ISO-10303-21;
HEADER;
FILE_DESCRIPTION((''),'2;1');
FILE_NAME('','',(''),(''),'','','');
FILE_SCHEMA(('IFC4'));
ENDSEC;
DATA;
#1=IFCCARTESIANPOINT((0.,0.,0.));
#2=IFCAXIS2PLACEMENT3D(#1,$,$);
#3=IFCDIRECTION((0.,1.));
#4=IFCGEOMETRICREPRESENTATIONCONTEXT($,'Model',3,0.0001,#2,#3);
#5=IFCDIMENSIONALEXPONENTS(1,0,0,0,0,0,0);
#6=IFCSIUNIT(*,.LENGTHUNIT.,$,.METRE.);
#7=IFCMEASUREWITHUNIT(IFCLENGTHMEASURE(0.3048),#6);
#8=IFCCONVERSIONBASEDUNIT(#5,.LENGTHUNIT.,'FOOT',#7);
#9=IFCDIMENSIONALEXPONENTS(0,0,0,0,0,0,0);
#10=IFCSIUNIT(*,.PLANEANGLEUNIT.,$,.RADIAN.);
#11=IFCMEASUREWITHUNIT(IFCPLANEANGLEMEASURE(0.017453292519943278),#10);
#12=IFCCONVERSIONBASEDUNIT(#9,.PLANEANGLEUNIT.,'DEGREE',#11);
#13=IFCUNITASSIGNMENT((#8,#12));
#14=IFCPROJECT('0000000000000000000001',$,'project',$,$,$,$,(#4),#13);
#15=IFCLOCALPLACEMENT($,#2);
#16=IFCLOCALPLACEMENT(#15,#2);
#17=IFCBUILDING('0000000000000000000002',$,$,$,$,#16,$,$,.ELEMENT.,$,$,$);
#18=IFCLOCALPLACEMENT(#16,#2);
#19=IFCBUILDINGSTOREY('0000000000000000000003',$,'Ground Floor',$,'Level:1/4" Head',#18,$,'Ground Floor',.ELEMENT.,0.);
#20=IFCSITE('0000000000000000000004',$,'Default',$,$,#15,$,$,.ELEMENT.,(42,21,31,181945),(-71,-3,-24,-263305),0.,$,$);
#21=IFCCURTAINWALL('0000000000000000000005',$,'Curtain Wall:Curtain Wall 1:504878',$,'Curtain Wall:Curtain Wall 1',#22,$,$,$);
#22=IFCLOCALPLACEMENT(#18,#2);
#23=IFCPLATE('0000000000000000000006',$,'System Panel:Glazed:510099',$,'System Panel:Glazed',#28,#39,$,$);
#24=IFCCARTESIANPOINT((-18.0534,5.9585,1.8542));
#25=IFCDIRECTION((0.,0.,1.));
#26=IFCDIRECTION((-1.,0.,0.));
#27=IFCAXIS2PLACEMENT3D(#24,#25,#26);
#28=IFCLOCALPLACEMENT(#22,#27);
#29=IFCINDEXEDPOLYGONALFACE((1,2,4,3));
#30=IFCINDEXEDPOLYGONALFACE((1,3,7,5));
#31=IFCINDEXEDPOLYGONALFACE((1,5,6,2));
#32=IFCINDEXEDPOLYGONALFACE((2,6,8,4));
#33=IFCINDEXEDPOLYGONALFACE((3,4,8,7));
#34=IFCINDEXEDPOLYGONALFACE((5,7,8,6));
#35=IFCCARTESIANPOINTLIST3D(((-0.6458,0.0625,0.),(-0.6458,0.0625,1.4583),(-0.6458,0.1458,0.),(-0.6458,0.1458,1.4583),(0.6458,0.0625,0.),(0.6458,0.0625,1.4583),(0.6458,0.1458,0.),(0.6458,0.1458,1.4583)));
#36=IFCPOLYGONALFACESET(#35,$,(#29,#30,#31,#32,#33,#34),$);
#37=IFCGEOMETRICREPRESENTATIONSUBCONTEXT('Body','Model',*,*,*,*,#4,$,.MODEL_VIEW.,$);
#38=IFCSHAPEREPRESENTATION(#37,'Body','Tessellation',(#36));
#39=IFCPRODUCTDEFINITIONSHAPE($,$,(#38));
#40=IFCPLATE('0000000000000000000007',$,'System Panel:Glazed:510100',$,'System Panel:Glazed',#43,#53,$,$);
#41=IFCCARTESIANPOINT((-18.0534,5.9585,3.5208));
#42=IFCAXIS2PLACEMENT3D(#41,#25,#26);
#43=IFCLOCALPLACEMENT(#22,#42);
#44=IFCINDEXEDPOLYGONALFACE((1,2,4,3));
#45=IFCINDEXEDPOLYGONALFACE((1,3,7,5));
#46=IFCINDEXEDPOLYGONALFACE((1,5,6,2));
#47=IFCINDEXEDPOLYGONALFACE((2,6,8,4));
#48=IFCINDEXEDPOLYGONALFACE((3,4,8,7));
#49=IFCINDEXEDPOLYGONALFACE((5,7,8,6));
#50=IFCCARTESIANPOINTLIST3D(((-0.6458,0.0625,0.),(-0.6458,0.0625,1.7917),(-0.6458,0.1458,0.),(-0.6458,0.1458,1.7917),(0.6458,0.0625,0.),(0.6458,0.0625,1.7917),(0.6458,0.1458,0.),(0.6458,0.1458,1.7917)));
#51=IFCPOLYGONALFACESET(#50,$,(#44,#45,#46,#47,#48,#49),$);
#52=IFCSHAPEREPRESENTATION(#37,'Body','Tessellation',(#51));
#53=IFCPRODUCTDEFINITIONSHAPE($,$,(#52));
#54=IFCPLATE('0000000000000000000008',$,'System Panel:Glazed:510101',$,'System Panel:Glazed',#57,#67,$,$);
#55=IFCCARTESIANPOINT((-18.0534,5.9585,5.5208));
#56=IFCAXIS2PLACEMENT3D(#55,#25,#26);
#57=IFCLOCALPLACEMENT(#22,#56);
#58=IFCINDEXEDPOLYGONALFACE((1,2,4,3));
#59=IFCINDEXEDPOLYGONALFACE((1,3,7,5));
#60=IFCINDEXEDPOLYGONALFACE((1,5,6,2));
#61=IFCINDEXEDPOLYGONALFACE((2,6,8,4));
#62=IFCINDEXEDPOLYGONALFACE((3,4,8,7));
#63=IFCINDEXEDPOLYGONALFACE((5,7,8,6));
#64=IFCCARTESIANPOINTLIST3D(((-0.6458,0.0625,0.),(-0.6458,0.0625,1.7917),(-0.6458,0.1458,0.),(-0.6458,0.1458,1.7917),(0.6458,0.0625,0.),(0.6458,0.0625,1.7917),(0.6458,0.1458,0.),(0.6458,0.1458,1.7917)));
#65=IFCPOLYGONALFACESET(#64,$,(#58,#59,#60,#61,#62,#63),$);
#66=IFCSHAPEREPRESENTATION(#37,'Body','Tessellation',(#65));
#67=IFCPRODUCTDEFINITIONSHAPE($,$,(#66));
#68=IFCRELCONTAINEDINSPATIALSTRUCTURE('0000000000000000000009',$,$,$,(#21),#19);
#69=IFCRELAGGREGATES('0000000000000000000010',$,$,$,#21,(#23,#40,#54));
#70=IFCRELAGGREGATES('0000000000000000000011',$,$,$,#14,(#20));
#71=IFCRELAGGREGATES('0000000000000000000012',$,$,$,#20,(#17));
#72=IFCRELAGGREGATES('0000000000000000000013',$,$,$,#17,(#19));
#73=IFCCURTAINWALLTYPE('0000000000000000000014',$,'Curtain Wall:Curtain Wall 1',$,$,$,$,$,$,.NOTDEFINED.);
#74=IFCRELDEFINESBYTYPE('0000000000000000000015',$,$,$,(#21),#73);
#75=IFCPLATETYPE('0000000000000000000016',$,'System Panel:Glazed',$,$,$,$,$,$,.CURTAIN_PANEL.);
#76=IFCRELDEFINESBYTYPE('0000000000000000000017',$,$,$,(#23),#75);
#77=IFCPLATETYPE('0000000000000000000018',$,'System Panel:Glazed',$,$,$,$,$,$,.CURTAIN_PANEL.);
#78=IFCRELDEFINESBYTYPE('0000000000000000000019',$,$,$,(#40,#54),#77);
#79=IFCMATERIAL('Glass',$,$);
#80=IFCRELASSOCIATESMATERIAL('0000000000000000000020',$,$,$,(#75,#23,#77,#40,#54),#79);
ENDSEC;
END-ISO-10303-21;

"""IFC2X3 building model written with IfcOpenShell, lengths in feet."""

from ifc_helpers import new_model, entity, si_unit, converted_unit, direction, frame, frame_2d, origin, place, context, subcontext, project, spatial, rectangle, extrude, source, transform, mapped, material, type_object, type_shapes, element, aggregate, save


model = new_model("IFC2X3")

# Units and contexts
model_context = context("Model", 3, precision=0.0001, world=origin(), true_north=direction((0.0, 1.0)))
body_context = subcontext(model_context, "Body", "Model", "MODEL_VIEW")
ifc_project = project(units=[converted_unit("LENGTHUNIT", "FOOT", entity("IfcLengthMeasure", 0.3048), si_unit("LENGTHUNIT", "METRE"), dimensions=[1, 0, 0, 0, 0, 0, 0]), converted_unit("PLANEANGLEUNIT", "DEGREE", entity("IfcPlaneAngleMeasure", 0.017453292519943278), si_unit("PLANEANGLEUNIT", "RADIAN"), dimensions=[0, 0, 0, 0, 0, 0, 0])], contexts=[model_context])

# Site, building, storey
site_placement = place(None, origin())
site = spatial("IfcSite", under=ifc_project, at=site_placement, Name="Default", CompositionType="ELEMENT", RefLatitude=(42, 21, 31, 181945), RefLongitude=(-71, -3, -24, -263305), RefElevation=0.0)
building_placement = place(site_placement, origin())
building = spatial("IfcBuilding", under=site, at=building_placement, CompositionType="ELEMENT")
storey_placement = place(building_placement, origin())
storey = spatial("IfcBuildingStorey", under=building, at=storey_placement, Name="Ground Floor", ObjectType="Level:1/4\" Head", LongName="Ground Floor", CompositionType="ELEMENT", Elevation=0.0)

# Curtain wall, plates
curtain_wall_type = type_object("IfcCurtainWallType", Name="Curtain Wall:Curtain Wall 1", PredefinedType="NOTDEFINED")
curtain_wall_placement = place(storey_placement, origin())
curtain_wall = element("IfcCurtainWall", 1, at=curtain_wall_placement, inside=storey, type_object=curtain_wall_type, Name="Curtain Wall:Curtain Wall 1:504878", ObjectType="Curtain Wall:Curtain Wall 1")
ifc_material_1 = material(Name="Glass")
plate_type_1 = type_object("IfcPlateType", Name="System Panel:Glazed", PredefinedType="CURTAIN_PANEL", material=ifc_material_1)
shared_shape_1 = source(origin(), body_context, "Body", "SweptSolid", [
    extrude(rectangle(XDim=0.0833, YDim=1.2917, at=frame_2d((0.0, 0.0), x_axis=(1.0, 0.0))), frame((0.0, 0.1042, 0.0), z_axis=(0.0, 0.0, 1.0), x_axis=(0.0, 1.0, 0.0)), (0.0, 0.0, 1.0), 1.4583),
])
type_shapes(plate_type_1, [shared_shape_1])
plate_1_placement = place(curtain_wall_placement, frame((-18.0534, 5.9585, 1.8542), z_axis=(0.0, 0.0, 1.0), x_axis=(-1.0, 0.0, 0.0)))
plate_1 = element("IfcPlate", 2, at=plate_1_placement, type_object=plate_type_1, material=ifc_material_1, Name="System Panel:Glazed:510099", ObjectType="System Panel:Glazed", context=body_context, shape_type="MappedRepresentation", body=[
    mapped(shared_shape_1, transform((0.0, 0.0, 0.0), scale=1.0)),
])
plate_type_2 = type_object("IfcPlateType", Name="System Panel:Glazed", PredefinedType="CURTAIN_PANEL", material=ifc_material_1)
shared_shape_2 = source(origin(), body_context, "Body", "SweptSolid", [
    extrude(rectangle(XDim=0.0833, YDim=1.2917, at=frame_2d((0.0, 0.0), x_axis=(1.0, 0.0))), frame((0.0, 0.1042, 0.0), z_axis=(0.0, 0.0, 1.0), x_axis=(0.0, 1.0, 0.0)), (0.0, 0.0, 1.0), 1.7917),
])
type_shapes(plate_type_2, [shared_shape_2])
plate_2_placement = place(curtain_wall_placement, frame((-18.0534, 5.9585, 3.5208), z_axis=(0.0, 0.0, 1.0), x_axis=(-1.0, 0.0, 0.0)))
plate_2 = element("IfcPlate", 3, at=plate_2_placement, type_object=plate_type_2, material=ifc_material_1, Name="System Panel:Glazed:510100", ObjectType="System Panel:Glazed", context=body_context, shape_type="MappedRepresentation", body=[
    mapped(shared_shape_2, transform((0.0, 0.0, 0.0), scale=1.0)),
])
plate_3_placement = place(curtain_wall_placement, frame((-18.0534, 5.9585, 5.5208), z_axis=(0.0, 0.0, 1.0), x_axis=(-1.0, 0.0, 0.0)))
plate_3 = element("IfcPlate", 4, at=plate_3_placement, type_object=plate_type_2, material=ifc_material_1, Name="System Panel:Glazed:510101", ObjectType="System Panel:Glazed", context=body_context, shape_type="MappedRepresentation", body=[
    mapped(shared_shape_2, transform((0.0, 0.0, 0.0), scale=1.0)),
])
aggregate(curtain_wall, [plate_1, plate_2, plate_3])

save(model, "model.ifc")
